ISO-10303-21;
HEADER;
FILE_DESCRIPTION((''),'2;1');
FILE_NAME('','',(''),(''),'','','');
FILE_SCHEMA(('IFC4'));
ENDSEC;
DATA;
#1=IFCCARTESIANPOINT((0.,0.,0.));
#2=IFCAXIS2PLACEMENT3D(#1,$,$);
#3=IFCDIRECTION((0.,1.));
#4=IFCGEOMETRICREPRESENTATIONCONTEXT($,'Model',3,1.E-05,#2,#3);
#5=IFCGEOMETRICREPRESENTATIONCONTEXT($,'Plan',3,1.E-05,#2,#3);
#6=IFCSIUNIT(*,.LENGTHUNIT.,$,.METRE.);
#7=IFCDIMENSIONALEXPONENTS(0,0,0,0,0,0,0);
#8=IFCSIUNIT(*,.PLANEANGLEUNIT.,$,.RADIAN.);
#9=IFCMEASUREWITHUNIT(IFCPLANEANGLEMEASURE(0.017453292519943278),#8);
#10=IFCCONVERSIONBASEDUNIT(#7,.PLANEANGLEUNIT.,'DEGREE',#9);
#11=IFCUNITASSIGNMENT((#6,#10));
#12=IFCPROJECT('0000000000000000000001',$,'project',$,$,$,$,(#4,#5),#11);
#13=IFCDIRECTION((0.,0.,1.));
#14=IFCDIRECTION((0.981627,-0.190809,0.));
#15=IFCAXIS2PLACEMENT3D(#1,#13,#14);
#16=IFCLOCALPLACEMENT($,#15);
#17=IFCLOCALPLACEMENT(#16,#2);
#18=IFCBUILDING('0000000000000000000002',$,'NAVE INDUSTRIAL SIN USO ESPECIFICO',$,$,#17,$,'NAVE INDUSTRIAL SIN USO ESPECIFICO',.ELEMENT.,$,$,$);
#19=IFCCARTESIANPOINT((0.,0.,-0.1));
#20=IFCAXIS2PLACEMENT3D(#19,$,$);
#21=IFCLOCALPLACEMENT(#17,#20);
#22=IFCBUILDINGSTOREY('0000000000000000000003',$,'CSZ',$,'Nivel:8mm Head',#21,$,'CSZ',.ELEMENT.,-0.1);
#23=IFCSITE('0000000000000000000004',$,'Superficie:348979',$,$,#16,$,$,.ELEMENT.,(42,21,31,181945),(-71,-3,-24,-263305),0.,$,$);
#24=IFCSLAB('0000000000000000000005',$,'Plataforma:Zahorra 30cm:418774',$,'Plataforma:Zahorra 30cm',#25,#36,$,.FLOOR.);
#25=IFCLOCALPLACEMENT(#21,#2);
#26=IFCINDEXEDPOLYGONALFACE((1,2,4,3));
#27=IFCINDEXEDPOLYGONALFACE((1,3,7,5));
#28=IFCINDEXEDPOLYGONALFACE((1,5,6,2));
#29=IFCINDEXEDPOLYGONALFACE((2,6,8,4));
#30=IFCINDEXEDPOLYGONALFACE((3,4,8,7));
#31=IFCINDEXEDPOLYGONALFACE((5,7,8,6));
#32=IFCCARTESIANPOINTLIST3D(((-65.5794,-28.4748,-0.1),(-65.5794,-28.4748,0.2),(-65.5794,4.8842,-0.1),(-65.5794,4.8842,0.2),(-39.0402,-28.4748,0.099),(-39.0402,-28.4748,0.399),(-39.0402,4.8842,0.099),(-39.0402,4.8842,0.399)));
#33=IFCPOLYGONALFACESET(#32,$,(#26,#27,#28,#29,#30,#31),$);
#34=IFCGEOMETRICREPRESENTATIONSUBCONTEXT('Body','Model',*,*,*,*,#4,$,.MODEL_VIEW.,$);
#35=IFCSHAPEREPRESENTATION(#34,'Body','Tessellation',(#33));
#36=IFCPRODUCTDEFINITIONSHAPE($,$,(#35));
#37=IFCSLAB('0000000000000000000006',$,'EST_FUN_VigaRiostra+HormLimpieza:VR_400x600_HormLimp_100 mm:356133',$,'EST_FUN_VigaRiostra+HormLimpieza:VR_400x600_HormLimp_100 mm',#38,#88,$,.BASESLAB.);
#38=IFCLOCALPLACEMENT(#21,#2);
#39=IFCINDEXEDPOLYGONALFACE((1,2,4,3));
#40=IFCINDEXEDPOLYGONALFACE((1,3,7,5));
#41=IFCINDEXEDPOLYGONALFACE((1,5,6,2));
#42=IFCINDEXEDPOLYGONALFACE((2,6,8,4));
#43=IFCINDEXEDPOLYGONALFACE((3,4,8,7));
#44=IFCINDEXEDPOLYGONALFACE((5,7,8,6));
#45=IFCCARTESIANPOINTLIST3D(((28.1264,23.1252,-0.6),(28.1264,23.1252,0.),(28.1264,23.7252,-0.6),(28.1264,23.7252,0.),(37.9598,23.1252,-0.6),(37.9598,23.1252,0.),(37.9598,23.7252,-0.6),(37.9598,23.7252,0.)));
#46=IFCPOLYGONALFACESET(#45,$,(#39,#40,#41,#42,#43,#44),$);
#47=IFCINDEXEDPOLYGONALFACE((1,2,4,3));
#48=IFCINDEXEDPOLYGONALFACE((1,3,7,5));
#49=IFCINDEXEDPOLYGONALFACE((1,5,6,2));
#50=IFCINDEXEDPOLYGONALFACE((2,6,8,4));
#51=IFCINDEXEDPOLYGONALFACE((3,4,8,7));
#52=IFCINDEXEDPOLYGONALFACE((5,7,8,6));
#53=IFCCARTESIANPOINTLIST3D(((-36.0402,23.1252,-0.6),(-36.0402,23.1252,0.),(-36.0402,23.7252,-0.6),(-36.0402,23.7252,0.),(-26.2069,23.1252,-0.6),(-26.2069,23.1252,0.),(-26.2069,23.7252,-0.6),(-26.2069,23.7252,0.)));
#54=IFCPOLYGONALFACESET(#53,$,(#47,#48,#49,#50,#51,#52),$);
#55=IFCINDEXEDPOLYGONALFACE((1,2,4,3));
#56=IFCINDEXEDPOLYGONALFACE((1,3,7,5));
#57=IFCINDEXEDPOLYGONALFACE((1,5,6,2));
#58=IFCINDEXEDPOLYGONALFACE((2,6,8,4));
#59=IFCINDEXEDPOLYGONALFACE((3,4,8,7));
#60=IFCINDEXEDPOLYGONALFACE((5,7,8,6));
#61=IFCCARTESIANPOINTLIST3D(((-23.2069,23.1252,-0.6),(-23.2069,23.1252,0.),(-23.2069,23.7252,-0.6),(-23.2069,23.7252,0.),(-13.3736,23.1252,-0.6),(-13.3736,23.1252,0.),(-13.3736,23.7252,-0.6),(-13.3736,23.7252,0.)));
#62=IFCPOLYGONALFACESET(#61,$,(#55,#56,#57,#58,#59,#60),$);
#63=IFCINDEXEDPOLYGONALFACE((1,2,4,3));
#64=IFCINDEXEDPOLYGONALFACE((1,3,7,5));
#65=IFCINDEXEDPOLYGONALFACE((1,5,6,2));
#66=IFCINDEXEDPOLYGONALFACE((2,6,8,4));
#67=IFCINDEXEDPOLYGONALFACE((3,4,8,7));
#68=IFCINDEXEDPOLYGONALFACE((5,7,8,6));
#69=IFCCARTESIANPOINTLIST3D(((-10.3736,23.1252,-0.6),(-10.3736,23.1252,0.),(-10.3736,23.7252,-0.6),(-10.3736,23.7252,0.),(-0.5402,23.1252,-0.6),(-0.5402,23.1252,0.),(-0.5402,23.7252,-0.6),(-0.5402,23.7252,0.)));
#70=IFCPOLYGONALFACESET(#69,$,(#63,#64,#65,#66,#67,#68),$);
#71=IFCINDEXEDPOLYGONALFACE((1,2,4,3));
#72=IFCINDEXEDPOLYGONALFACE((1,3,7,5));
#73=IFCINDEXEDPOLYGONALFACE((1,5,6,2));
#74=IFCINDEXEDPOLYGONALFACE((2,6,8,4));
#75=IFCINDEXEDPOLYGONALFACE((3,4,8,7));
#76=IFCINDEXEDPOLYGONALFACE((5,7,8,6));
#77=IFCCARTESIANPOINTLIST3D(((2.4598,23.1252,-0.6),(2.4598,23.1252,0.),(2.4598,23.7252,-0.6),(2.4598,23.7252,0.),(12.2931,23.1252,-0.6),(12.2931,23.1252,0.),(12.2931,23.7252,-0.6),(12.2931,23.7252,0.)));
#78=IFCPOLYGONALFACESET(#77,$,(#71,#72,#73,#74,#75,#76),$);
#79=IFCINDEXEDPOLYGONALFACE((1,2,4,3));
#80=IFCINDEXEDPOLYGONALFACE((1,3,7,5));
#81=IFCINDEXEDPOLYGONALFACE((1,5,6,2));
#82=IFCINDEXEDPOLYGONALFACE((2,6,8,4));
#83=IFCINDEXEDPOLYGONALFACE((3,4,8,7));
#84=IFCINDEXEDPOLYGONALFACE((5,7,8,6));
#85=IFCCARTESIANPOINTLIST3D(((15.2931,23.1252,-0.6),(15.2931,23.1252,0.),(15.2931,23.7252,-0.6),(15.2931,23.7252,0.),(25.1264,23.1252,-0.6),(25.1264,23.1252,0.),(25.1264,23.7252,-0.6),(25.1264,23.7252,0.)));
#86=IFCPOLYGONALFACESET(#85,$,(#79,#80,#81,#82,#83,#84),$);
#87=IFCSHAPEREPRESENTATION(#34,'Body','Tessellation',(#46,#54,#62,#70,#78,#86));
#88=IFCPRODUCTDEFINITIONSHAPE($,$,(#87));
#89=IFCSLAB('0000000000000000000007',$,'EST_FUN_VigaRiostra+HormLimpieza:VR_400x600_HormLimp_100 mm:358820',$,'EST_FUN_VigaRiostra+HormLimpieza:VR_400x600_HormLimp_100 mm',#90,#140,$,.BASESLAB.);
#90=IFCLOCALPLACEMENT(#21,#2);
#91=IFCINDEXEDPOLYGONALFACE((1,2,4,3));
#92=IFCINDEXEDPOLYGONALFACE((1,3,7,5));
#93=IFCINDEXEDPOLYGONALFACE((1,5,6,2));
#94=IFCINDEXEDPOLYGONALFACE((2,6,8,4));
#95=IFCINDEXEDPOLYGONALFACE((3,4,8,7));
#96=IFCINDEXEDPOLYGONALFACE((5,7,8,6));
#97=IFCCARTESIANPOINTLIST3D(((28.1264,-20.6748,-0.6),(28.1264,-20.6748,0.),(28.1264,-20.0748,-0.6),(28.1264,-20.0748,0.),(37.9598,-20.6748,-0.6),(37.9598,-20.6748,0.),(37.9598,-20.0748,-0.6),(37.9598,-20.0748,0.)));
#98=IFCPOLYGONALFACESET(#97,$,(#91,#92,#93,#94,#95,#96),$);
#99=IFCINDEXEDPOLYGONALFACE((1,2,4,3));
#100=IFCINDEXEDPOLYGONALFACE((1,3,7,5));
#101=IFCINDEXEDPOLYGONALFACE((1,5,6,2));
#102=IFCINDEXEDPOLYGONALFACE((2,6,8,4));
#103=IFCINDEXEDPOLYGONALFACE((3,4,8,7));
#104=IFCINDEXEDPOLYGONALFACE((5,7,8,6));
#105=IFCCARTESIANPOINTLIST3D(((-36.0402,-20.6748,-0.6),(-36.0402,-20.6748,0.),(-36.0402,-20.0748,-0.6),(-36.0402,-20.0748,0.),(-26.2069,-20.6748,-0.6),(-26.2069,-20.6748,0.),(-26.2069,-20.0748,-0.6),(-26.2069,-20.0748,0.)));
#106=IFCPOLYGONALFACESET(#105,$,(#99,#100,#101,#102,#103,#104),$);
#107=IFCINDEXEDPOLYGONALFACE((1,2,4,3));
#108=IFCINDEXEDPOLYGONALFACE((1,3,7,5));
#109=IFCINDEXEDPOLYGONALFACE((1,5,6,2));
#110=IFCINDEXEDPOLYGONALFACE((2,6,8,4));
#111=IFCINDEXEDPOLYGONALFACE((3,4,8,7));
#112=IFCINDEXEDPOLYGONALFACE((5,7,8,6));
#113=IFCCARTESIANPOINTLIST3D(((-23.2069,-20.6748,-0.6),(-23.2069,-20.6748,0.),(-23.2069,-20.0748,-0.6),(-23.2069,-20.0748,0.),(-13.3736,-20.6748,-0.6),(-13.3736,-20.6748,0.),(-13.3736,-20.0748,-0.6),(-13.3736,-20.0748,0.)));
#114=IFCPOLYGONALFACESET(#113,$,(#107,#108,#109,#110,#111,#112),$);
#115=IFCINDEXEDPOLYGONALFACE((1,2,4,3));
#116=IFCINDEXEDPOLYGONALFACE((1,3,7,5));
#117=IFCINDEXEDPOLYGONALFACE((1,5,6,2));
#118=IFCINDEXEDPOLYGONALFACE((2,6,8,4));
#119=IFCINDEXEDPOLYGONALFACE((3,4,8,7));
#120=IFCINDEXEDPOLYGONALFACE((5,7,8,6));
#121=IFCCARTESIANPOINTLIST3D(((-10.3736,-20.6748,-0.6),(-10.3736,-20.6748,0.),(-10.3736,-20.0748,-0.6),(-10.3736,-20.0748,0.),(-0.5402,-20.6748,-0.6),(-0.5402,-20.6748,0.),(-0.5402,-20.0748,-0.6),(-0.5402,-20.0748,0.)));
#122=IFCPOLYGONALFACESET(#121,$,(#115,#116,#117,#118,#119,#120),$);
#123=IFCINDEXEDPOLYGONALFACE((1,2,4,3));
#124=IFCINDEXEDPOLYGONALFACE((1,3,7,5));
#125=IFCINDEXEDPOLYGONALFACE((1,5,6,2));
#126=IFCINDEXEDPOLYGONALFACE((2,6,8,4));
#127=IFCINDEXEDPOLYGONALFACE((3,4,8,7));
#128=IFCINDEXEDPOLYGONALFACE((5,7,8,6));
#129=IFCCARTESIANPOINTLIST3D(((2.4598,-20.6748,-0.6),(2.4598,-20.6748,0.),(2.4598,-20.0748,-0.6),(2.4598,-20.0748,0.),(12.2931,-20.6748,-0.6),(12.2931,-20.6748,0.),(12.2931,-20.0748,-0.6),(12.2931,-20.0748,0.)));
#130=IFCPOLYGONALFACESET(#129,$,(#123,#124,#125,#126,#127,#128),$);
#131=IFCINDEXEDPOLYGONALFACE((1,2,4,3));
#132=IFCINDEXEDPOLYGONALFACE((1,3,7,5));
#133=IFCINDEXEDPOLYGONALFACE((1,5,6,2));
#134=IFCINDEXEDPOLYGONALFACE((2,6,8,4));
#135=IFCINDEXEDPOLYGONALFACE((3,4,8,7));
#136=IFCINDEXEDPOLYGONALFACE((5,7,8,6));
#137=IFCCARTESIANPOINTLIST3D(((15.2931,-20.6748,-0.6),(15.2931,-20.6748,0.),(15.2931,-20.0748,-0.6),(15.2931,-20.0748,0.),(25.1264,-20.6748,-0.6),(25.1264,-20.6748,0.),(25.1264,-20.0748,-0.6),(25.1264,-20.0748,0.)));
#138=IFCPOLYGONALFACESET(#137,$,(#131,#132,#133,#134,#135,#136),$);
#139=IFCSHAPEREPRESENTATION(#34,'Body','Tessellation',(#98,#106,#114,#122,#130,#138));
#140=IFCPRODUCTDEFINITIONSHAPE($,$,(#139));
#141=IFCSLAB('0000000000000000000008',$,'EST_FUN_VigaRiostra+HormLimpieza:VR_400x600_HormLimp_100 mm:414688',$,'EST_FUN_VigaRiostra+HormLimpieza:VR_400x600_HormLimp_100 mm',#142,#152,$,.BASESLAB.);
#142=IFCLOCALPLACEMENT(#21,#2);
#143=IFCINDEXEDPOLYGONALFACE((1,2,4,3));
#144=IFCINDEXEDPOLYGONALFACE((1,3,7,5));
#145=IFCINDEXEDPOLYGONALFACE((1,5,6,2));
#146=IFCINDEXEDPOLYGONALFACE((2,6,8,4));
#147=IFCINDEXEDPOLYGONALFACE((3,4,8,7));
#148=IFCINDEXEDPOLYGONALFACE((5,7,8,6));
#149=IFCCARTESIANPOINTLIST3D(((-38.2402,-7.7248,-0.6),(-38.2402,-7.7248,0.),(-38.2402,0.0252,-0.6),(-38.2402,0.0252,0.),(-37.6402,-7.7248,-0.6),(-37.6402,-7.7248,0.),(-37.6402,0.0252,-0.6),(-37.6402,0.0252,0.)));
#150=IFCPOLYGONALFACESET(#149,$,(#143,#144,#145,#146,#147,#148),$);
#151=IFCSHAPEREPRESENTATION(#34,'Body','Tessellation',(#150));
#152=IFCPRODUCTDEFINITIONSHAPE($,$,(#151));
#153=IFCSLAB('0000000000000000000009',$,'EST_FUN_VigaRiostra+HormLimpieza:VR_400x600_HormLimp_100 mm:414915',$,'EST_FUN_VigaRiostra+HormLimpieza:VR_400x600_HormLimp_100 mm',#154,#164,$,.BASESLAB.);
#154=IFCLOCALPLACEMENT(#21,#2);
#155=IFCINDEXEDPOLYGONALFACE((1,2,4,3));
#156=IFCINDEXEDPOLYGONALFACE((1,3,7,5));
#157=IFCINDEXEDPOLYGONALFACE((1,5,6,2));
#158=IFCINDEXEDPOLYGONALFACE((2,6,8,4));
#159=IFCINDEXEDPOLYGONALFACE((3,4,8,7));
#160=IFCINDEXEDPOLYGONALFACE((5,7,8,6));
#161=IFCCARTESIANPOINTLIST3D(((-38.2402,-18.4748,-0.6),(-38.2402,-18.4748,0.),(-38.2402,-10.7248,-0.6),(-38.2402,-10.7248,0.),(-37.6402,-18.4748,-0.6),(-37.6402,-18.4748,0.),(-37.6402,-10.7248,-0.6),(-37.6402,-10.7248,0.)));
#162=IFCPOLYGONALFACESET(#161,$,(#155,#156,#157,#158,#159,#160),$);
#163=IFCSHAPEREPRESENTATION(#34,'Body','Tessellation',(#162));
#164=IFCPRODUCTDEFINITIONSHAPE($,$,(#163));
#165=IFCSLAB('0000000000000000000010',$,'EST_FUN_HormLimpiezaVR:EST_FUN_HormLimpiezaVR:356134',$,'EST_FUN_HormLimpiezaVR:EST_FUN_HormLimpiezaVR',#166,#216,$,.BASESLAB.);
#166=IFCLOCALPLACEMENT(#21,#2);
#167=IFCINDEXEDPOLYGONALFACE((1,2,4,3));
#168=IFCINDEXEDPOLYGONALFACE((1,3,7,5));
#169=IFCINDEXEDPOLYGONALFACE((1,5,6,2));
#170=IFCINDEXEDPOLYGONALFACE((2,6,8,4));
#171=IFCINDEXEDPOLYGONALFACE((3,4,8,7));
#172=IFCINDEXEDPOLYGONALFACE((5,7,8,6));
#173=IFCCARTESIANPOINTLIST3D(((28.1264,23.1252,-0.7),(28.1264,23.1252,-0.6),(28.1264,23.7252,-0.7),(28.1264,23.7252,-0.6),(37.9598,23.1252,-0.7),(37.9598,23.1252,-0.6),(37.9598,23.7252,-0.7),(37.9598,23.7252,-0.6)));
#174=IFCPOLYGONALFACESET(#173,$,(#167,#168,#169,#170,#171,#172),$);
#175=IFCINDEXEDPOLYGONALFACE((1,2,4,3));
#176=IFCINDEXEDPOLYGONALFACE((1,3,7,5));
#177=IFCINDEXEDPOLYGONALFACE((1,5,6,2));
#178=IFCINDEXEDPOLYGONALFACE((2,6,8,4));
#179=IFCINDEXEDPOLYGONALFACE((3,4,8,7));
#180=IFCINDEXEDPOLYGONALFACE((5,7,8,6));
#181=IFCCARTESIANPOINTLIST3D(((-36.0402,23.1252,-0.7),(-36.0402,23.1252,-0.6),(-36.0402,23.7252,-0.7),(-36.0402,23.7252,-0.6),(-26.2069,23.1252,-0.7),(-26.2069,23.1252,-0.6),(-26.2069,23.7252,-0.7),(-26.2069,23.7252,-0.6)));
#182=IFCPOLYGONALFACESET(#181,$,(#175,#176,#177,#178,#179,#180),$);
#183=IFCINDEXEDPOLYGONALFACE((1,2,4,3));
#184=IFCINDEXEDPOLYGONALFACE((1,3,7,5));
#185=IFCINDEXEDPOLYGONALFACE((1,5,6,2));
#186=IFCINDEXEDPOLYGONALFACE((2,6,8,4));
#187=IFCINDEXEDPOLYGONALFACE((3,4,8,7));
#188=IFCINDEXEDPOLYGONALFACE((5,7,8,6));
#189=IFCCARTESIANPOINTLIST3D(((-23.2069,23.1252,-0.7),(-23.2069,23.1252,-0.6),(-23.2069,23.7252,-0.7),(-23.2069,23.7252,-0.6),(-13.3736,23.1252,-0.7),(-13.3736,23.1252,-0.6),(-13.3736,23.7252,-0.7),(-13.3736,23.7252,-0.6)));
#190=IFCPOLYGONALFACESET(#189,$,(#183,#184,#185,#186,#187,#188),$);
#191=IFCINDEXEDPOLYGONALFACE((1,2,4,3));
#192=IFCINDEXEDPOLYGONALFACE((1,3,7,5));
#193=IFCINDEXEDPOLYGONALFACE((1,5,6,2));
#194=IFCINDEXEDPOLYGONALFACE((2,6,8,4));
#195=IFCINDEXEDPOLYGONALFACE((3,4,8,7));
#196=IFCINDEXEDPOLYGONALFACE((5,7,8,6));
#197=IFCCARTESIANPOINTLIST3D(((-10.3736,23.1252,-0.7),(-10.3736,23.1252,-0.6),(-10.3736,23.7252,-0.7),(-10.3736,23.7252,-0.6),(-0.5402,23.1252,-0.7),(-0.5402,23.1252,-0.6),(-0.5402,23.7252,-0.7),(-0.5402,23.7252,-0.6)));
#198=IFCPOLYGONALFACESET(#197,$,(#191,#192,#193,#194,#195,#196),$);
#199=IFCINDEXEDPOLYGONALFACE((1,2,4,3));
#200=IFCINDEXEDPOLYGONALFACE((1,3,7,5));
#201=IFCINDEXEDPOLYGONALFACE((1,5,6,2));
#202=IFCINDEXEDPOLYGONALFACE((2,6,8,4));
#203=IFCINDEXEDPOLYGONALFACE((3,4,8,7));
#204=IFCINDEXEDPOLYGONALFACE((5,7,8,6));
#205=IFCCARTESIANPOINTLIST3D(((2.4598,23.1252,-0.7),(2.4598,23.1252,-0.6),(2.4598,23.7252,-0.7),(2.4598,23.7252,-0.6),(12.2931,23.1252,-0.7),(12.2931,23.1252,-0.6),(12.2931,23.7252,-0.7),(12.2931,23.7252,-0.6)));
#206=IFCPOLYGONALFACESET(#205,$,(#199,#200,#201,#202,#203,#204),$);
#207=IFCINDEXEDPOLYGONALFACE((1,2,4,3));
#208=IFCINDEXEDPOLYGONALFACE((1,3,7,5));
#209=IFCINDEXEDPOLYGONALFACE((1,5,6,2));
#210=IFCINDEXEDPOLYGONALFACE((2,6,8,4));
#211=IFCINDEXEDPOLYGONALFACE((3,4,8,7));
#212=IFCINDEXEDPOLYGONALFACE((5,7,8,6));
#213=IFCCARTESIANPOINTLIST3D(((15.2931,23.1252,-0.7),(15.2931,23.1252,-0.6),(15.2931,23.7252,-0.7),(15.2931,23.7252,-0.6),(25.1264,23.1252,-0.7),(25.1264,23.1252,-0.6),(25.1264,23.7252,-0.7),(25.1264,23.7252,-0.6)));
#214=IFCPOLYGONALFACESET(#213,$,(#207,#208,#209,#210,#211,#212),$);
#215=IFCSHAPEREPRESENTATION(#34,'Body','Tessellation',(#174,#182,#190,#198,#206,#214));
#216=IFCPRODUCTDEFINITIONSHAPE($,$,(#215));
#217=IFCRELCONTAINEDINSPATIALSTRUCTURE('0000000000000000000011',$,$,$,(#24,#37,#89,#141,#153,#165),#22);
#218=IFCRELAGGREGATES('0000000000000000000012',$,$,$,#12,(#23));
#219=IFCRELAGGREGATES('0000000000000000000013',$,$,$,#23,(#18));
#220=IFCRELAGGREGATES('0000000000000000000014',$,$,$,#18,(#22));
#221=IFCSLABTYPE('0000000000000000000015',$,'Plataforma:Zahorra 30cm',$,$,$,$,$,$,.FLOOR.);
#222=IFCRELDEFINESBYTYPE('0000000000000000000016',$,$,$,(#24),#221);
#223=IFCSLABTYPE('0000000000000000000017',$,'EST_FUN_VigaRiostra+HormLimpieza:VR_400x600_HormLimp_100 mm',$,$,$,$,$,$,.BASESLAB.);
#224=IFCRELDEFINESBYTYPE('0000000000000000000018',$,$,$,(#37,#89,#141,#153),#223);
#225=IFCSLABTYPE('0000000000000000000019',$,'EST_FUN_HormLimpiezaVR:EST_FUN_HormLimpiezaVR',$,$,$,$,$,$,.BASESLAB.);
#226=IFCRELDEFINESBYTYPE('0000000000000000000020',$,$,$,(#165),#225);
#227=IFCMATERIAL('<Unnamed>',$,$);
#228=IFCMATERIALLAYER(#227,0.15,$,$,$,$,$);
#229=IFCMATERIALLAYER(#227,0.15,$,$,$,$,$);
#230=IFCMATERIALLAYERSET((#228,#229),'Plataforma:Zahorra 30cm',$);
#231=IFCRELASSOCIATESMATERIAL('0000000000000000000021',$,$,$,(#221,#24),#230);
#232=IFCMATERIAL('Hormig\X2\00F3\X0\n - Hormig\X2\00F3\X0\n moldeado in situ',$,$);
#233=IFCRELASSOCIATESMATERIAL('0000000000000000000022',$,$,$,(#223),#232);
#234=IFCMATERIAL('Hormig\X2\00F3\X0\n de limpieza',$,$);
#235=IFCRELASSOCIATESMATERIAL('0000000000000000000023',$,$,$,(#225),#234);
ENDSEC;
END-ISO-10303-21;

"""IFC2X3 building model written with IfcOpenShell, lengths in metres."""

from ifc_helpers import new_model, entity, si_unit, converted_unit, direction, frame, frame_2d, origin, origin_2d_with_axis, place, context, subcontext, project, spatial, rectangle, extrude, material, layer, layer_set, layer_usage, type_object, element, save


model = new_model("IFC2X3")

# Units and contexts
model_context = context("Model", 3, precision=1e-05, world=origin(), true_north=direction((0.0, 1.0)))
plan_context = context("Plan", 3, precision=1e-05, world=origin(), true_north=direction((0.0, 1.0)))
body_context = subcontext(model_context, "Body", "Model", "MODEL_VIEW")
ifc_project = project(units=[si_unit("LENGTHUNIT", "METRE"), converted_unit("PLANEANGLEUNIT", "DEGREE", entity("IfcPlaneAngleMeasure", 0.017453292519943278), si_unit("PLANEANGLEUNIT", "RADIAN"), dimensions=[0, 0, 0, 0, 0, 0, 0])], contexts=[model_context, plan_context])

# Site, building, storey
site_placement = place(None, frame((0.0, 0.0, 0.0), z_axis=(0.0, 0.0, 1.0), x_axis=(0.981627, -0.190809, 0.0)))
site = spatial("IfcSite", under=ifc_project, at=site_placement, Name="Superficie:348979", CompositionType="ELEMENT", RefLatitude=(42, 21, 31, 181945), RefLongitude=(-71, -3, -24, -263305), RefElevation=0.0)
building_placement = place(site_placement, origin())
building = spatial("IfcBuilding", under=site, at=building_placement, Name="NAVE INDUSTRIAL SIN USO ESPECIFICO", LongName="NAVE INDUSTRIAL SIN USO ESPECIFICO", CompositionType="ELEMENT")
storey_placement = place(building_placement, frame((0.0, 0.0, -0.1)))
storey = spatial("IfcBuildingStorey", under=building, at=storey_placement, Name="CSZ", ObjectType="Nivel:8mm Head", LongName="CSZ", CompositionType="ELEMENT", Elevation=-0.1)

# Shared definitions
ifc_material_1 = material(Name="<Unnamed>")

# Slabs
ifc_layer_1 = layer(ifc_material_1, 0.15)
ifc_layer_2 = layer(ifc_material_1, 0.15)
ifc_layer_set_1 = layer_set([ifc_layer_1, ifc_layer_2], Name="Plataforma:Zahorra 30cm")
ifc_layer_usage_1 = layer_usage(ifc_layer_set_1, "AXIS3", "NEGATIVE", 0.0)
slab_type_1 = type_object("IfcSlabType", Name="Plataforma:Zahorra 30cm", PredefinedType="FLOOR", material=ifc_layer_set_1)
slab_1_placement = place(storey_placement, frame((-65.5794, -28.4748, -0.1)))
element("IfcSlab", 1, at=slab_1_placement, inside=storey, type_object=slab_type_1, material=ifc_layer_usage_1, Name="Plataforma:Zahorra 30cm:418774", ObjectType="Plataforma:Zahorra 30cm", PredefinedType="FLOOR", context=body_context, shape_type="SweptSolid", body=[
    extrude(rectangle(XDim=26.54, YDim=33.359, at=frame_2d((13.27, 0.0), x_axis=(-1.0, 0.0))), frame((0.0, 16.6795, 0.3), z_axis=(-0.0075, 0.0, 0.999972), x_axis=(0.999972, 0.0, 0.0075)), (-0.0075, 0.0, -0.999972), 0.3),
])
ifc_material_2 = material(Name="Hormigón - Hormigón moldeado in situ")
slab_type_2 = type_object("IfcSlabType", Name="EST_FUN_VigaRiostra+HormLimpieza:VR_400x600_HormLimp_100 mm", PredefinedType="BASESLAB", material=ifc_material_2)
slab_2_placement = place(storey_placement, frame((-36.0402, 23.1252, -0.6)))
element("IfcSlab", 2, at=slab_2_placement, inside=storey, type_object=slab_type_2, Name="EST_FUN_VigaRiostra+HormLimpieza:VR_400x600_HormLimp_100 mm:356133", ObjectType="EST_FUN_VigaRiostra+HormLimpieza:VR_400x600_HormLimp_100 mm", PredefinedType="BASESLAB", context=body_context, shape_type="SweptSolid", body=[
    extrude(rectangle(XDim=9.8333, YDim=0.6, at=frame_2d((0.0, 0.0), x_axis=(1.0, 0.0))), frame((69.0833, 0.3, 0.0)), (0.0, 0.0, 1.0), 0.6),
    extrude(rectangle(XDim=9.8333, YDim=0.6, at=frame_2d((0.0, 0.0), x_axis=(1.0, 0.0))), frame((4.9167, 0.3, 0.0), z_axis=(0.0, 0.0, 1.0), x_axis=(-1.0, 0.0, 0.0)), (0.0, 0.0, 1.0), 0.6),
    extrude(rectangle(XDim=9.8333, YDim=0.6, at=frame_2d((0.0, 0.0), x_axis=(1.0, 0.0))), frame((17.75, 0.3, 0.0)), (0.0, 0.0, 1.0), 0.6),
    extrude(rectangle(XDim=9.8333, YDim=0.6, at=frame_2d((0.0, 0.0), x_axis=(1.0, 0.0))), frame((30.5833, 0.3, 0.0)), (0.0, 0.0, 1.0), 0.6),
    extrude(rectangle(XDim=9.8333, YDim=0.6, at=frame_2d((0.0, 0.0), x_axis=(1.0, 0.0))), frame((43.4167, 0.3, 0.0)), (0.0, 0.0, 1.0), 0.6),
    extrude(rectangle(XDim=9.8333, YDim=0.6, at=frame_2d((0.0, 0.0), x_axis=(1.0, 0.0))), frame((56.25, 0.3, 0.0)), (0.0, 0.0, 1.0), 0.6),
])
slab_3_placement = place(storey_placement, frame((-36.0402, -20.6748, -0.6)))
element("IfcSlab", 3, at=slab_3_placement, inside=storey, type_object=slab_type_2, Name="EST_FUN_VigaRiostra+HormLimpieza:VR_400x600_HormLimp_100 mm:358820", ObjectType="EST_FUN_VigaRiostra+HormLimpieza:VR_400x600_HormLimp_100 mm", PredefinedType="BASESLAB", context=body_context, shape_type="SweptSolid", body=[
    extrude(rectangle(XDim=9.8333, YDim=0.6, at=frame_2d((0.0, 0.0), x_axis=(1.0, 0.0))), frame((69.0833, 0.3, 0.0)), (0.0, 0.0, 1.0), 0.6),
    extrude(rectangle(XDim=9.8333, YDim=0.6, at=frame_2d((0.0, 0.0), x_axis=(1.0, 0.0))), frame((4.9167, 0.3, 0.0)), (0.0, 0.0, 1.0), 0.6),
    extrude(rectangle(XDim=9.8333, YDim=0.6, at=frame_2d((0.0, 0.0), x_axis=(1.0, 0.0))), frame((17.75, 0.3, 0.0)), (0.0, 0.0, 1.0), 0.6),
    extrude(rectangle(XDim=9.8333, YDim=0.6, at=frame_2d((0.0, 0.0), x_axis=(1.0, 0.0))), frame((30.5833, 0.3, 0.0)), (0.0, 0.0, 1.0), 0.6),
    extrude(rectangle(XDim=9.8333, YDim=0.6, at=origin_2d_with_axis()), frame((43.4167, 0.3, 0.0)), (0.0, 0.0, 1.0), 0.6),
    extrude(rectangle(XDim=9.8333, YDim=0.6, at=origin_2d_with_axis()), frame((56.25, 0.3, 0.0)), (0.0, 0.0, 1.0), 0.6),
])
slab_4_placement = place(storey_placement, frame((-38.2402, -7.7248, -0.6)))
element("IfcSlab", 4, at=slab_4_placement, inside=storey, type_object=slab_type_2, Name="EST_FUN_VigaRiostra+HormLimpieza:VR_400x600_HormLimp_100 mm:414688", ObjectType="EST_FUN_VigaRiostra+HormLimpieza:VR_400x600_HormLimp_100 mm", PredefinedType="BASESLAB", context=body_context, shape_type="SweptSolid", body=[
    extrude(rectangle(XDim=7.75, YDim=0.6, at=frame_2d((0.0, 0.0), x_axis=(1.0, 0.0))), frame((0.3, 3.875, 0.0), z_axis=(0.0, 0.0, 1.0), x_axis=(0.0, 1.0, 0.0)), (0.0, 0.0, 1.0), 0.6),
])
slab_5_placement = place(storey_placement, frame((-38.2402, -18.4748, -0.6)))
element("IfcSlab", 5, at=slab_5_placement, inside=storey, type_object=slab_type_2, Name="EST_FUN_VigaRiostra+HormLimpieza:VR_400x600_HormLimp_100 mm:414915", ObjectType="EST_FUN_VigaRiostra+HormLimpieza:VR_400x600_HormLimp_100 mm", PredefinedType="BASESLAB", context=body_context, shape_type="SweptSolid", body=[
    extrude(rectangle(XDim=7.75, YDim=0.6, at=frame_2d((0.0, 0.0), x_axis=(1.0, 0.0))), frame((0.3, 3.875, 0.0), z_axis=(0.0, 0.0, 1.0), x_axis=(0.0, 1.0, 0.0)), (0.0, 0.0, 1.0), 0.6),
])
ifc_material_3 = material(Name="Hormigón de limpieza")
slab_type_3 = type_object("IfcSlabType", Name="EST_FUN_HormLimpiezaVR:EST_FUN_HormLimpiezaVR", PredefinedType="BASESLAB", material=ifc_material_3)
slab_6_placement = place(storey_placement, frame((-36.0402, 23.1252, -0.7)))
element("IfcSlab", 6, at=slab_6_placement, inside=storey, type_object=slab_type_3, Name="EST_FUN_HormLimpiezaVR:EST_FUN_HormLimpiezaVR:356134", ObjectType="EST_FUN_HormLimpiezaVR:EST_FUN_HormLimpiezaVR", PredefinedType="BASESLAB", context=body_context, shape_type="SweptSolid", body=[
    extrude(rectangle(XDim=9.8333, YDim=0.6, at=frame_2d((0.0, 0.0), x_axis=(1.0, 0.0))), frame((69.0833, 0.3, 0.0)), (0.0, 0.0, 1.0), 0.1),
    extrude(rectangle(XDim=9.8333, YDim=0.6, at=frame_2d((0.0, 0.0), x_axis=(1.0, 0.0))), frame((4.9167, 0.3, 0.0), z_axis=(0.0, 0.0, 1.0), x_axis=(-1.0, 0.0, 0.0)), (0.0, 0.0, 1.0), 0.1),
    extrude(rectangle(XDim=9.8333, YDim=0.6, at=frame_2d((0.0, 0.0), x_axis=(1.0, 0.0))), frame((17.75, 0.3, 0.0)), (0.0, 0.0, 1.0), 0.1),
    extrude(rectangle(XDim=9.8333, YDim=0.6, at=frame_2d((0.0, 0.0), x_axis=(1.0, 0.0))), frame((30.5833, 0.3, 0.0)), (0.0, 0.0, 1.0), 0.1),
    extrude(rectangle(XDim=9.8333, YDim=0.6, at=frame_2d((0.0, 0.0), x_axis=(1.0, 0.0))), frame((43.4167, 0.3, 0.0)), (0.0, 0.0, 1.0), 0.1),
    extrude(rectangle(XDim=9.8333, YDim=0.6, at=origin_2d_with_axis()), frame((56.25, 0.3, 0.0)), (0.0, 0.0, 1.0), 0.1),
])

save(model, "model.ifc")
